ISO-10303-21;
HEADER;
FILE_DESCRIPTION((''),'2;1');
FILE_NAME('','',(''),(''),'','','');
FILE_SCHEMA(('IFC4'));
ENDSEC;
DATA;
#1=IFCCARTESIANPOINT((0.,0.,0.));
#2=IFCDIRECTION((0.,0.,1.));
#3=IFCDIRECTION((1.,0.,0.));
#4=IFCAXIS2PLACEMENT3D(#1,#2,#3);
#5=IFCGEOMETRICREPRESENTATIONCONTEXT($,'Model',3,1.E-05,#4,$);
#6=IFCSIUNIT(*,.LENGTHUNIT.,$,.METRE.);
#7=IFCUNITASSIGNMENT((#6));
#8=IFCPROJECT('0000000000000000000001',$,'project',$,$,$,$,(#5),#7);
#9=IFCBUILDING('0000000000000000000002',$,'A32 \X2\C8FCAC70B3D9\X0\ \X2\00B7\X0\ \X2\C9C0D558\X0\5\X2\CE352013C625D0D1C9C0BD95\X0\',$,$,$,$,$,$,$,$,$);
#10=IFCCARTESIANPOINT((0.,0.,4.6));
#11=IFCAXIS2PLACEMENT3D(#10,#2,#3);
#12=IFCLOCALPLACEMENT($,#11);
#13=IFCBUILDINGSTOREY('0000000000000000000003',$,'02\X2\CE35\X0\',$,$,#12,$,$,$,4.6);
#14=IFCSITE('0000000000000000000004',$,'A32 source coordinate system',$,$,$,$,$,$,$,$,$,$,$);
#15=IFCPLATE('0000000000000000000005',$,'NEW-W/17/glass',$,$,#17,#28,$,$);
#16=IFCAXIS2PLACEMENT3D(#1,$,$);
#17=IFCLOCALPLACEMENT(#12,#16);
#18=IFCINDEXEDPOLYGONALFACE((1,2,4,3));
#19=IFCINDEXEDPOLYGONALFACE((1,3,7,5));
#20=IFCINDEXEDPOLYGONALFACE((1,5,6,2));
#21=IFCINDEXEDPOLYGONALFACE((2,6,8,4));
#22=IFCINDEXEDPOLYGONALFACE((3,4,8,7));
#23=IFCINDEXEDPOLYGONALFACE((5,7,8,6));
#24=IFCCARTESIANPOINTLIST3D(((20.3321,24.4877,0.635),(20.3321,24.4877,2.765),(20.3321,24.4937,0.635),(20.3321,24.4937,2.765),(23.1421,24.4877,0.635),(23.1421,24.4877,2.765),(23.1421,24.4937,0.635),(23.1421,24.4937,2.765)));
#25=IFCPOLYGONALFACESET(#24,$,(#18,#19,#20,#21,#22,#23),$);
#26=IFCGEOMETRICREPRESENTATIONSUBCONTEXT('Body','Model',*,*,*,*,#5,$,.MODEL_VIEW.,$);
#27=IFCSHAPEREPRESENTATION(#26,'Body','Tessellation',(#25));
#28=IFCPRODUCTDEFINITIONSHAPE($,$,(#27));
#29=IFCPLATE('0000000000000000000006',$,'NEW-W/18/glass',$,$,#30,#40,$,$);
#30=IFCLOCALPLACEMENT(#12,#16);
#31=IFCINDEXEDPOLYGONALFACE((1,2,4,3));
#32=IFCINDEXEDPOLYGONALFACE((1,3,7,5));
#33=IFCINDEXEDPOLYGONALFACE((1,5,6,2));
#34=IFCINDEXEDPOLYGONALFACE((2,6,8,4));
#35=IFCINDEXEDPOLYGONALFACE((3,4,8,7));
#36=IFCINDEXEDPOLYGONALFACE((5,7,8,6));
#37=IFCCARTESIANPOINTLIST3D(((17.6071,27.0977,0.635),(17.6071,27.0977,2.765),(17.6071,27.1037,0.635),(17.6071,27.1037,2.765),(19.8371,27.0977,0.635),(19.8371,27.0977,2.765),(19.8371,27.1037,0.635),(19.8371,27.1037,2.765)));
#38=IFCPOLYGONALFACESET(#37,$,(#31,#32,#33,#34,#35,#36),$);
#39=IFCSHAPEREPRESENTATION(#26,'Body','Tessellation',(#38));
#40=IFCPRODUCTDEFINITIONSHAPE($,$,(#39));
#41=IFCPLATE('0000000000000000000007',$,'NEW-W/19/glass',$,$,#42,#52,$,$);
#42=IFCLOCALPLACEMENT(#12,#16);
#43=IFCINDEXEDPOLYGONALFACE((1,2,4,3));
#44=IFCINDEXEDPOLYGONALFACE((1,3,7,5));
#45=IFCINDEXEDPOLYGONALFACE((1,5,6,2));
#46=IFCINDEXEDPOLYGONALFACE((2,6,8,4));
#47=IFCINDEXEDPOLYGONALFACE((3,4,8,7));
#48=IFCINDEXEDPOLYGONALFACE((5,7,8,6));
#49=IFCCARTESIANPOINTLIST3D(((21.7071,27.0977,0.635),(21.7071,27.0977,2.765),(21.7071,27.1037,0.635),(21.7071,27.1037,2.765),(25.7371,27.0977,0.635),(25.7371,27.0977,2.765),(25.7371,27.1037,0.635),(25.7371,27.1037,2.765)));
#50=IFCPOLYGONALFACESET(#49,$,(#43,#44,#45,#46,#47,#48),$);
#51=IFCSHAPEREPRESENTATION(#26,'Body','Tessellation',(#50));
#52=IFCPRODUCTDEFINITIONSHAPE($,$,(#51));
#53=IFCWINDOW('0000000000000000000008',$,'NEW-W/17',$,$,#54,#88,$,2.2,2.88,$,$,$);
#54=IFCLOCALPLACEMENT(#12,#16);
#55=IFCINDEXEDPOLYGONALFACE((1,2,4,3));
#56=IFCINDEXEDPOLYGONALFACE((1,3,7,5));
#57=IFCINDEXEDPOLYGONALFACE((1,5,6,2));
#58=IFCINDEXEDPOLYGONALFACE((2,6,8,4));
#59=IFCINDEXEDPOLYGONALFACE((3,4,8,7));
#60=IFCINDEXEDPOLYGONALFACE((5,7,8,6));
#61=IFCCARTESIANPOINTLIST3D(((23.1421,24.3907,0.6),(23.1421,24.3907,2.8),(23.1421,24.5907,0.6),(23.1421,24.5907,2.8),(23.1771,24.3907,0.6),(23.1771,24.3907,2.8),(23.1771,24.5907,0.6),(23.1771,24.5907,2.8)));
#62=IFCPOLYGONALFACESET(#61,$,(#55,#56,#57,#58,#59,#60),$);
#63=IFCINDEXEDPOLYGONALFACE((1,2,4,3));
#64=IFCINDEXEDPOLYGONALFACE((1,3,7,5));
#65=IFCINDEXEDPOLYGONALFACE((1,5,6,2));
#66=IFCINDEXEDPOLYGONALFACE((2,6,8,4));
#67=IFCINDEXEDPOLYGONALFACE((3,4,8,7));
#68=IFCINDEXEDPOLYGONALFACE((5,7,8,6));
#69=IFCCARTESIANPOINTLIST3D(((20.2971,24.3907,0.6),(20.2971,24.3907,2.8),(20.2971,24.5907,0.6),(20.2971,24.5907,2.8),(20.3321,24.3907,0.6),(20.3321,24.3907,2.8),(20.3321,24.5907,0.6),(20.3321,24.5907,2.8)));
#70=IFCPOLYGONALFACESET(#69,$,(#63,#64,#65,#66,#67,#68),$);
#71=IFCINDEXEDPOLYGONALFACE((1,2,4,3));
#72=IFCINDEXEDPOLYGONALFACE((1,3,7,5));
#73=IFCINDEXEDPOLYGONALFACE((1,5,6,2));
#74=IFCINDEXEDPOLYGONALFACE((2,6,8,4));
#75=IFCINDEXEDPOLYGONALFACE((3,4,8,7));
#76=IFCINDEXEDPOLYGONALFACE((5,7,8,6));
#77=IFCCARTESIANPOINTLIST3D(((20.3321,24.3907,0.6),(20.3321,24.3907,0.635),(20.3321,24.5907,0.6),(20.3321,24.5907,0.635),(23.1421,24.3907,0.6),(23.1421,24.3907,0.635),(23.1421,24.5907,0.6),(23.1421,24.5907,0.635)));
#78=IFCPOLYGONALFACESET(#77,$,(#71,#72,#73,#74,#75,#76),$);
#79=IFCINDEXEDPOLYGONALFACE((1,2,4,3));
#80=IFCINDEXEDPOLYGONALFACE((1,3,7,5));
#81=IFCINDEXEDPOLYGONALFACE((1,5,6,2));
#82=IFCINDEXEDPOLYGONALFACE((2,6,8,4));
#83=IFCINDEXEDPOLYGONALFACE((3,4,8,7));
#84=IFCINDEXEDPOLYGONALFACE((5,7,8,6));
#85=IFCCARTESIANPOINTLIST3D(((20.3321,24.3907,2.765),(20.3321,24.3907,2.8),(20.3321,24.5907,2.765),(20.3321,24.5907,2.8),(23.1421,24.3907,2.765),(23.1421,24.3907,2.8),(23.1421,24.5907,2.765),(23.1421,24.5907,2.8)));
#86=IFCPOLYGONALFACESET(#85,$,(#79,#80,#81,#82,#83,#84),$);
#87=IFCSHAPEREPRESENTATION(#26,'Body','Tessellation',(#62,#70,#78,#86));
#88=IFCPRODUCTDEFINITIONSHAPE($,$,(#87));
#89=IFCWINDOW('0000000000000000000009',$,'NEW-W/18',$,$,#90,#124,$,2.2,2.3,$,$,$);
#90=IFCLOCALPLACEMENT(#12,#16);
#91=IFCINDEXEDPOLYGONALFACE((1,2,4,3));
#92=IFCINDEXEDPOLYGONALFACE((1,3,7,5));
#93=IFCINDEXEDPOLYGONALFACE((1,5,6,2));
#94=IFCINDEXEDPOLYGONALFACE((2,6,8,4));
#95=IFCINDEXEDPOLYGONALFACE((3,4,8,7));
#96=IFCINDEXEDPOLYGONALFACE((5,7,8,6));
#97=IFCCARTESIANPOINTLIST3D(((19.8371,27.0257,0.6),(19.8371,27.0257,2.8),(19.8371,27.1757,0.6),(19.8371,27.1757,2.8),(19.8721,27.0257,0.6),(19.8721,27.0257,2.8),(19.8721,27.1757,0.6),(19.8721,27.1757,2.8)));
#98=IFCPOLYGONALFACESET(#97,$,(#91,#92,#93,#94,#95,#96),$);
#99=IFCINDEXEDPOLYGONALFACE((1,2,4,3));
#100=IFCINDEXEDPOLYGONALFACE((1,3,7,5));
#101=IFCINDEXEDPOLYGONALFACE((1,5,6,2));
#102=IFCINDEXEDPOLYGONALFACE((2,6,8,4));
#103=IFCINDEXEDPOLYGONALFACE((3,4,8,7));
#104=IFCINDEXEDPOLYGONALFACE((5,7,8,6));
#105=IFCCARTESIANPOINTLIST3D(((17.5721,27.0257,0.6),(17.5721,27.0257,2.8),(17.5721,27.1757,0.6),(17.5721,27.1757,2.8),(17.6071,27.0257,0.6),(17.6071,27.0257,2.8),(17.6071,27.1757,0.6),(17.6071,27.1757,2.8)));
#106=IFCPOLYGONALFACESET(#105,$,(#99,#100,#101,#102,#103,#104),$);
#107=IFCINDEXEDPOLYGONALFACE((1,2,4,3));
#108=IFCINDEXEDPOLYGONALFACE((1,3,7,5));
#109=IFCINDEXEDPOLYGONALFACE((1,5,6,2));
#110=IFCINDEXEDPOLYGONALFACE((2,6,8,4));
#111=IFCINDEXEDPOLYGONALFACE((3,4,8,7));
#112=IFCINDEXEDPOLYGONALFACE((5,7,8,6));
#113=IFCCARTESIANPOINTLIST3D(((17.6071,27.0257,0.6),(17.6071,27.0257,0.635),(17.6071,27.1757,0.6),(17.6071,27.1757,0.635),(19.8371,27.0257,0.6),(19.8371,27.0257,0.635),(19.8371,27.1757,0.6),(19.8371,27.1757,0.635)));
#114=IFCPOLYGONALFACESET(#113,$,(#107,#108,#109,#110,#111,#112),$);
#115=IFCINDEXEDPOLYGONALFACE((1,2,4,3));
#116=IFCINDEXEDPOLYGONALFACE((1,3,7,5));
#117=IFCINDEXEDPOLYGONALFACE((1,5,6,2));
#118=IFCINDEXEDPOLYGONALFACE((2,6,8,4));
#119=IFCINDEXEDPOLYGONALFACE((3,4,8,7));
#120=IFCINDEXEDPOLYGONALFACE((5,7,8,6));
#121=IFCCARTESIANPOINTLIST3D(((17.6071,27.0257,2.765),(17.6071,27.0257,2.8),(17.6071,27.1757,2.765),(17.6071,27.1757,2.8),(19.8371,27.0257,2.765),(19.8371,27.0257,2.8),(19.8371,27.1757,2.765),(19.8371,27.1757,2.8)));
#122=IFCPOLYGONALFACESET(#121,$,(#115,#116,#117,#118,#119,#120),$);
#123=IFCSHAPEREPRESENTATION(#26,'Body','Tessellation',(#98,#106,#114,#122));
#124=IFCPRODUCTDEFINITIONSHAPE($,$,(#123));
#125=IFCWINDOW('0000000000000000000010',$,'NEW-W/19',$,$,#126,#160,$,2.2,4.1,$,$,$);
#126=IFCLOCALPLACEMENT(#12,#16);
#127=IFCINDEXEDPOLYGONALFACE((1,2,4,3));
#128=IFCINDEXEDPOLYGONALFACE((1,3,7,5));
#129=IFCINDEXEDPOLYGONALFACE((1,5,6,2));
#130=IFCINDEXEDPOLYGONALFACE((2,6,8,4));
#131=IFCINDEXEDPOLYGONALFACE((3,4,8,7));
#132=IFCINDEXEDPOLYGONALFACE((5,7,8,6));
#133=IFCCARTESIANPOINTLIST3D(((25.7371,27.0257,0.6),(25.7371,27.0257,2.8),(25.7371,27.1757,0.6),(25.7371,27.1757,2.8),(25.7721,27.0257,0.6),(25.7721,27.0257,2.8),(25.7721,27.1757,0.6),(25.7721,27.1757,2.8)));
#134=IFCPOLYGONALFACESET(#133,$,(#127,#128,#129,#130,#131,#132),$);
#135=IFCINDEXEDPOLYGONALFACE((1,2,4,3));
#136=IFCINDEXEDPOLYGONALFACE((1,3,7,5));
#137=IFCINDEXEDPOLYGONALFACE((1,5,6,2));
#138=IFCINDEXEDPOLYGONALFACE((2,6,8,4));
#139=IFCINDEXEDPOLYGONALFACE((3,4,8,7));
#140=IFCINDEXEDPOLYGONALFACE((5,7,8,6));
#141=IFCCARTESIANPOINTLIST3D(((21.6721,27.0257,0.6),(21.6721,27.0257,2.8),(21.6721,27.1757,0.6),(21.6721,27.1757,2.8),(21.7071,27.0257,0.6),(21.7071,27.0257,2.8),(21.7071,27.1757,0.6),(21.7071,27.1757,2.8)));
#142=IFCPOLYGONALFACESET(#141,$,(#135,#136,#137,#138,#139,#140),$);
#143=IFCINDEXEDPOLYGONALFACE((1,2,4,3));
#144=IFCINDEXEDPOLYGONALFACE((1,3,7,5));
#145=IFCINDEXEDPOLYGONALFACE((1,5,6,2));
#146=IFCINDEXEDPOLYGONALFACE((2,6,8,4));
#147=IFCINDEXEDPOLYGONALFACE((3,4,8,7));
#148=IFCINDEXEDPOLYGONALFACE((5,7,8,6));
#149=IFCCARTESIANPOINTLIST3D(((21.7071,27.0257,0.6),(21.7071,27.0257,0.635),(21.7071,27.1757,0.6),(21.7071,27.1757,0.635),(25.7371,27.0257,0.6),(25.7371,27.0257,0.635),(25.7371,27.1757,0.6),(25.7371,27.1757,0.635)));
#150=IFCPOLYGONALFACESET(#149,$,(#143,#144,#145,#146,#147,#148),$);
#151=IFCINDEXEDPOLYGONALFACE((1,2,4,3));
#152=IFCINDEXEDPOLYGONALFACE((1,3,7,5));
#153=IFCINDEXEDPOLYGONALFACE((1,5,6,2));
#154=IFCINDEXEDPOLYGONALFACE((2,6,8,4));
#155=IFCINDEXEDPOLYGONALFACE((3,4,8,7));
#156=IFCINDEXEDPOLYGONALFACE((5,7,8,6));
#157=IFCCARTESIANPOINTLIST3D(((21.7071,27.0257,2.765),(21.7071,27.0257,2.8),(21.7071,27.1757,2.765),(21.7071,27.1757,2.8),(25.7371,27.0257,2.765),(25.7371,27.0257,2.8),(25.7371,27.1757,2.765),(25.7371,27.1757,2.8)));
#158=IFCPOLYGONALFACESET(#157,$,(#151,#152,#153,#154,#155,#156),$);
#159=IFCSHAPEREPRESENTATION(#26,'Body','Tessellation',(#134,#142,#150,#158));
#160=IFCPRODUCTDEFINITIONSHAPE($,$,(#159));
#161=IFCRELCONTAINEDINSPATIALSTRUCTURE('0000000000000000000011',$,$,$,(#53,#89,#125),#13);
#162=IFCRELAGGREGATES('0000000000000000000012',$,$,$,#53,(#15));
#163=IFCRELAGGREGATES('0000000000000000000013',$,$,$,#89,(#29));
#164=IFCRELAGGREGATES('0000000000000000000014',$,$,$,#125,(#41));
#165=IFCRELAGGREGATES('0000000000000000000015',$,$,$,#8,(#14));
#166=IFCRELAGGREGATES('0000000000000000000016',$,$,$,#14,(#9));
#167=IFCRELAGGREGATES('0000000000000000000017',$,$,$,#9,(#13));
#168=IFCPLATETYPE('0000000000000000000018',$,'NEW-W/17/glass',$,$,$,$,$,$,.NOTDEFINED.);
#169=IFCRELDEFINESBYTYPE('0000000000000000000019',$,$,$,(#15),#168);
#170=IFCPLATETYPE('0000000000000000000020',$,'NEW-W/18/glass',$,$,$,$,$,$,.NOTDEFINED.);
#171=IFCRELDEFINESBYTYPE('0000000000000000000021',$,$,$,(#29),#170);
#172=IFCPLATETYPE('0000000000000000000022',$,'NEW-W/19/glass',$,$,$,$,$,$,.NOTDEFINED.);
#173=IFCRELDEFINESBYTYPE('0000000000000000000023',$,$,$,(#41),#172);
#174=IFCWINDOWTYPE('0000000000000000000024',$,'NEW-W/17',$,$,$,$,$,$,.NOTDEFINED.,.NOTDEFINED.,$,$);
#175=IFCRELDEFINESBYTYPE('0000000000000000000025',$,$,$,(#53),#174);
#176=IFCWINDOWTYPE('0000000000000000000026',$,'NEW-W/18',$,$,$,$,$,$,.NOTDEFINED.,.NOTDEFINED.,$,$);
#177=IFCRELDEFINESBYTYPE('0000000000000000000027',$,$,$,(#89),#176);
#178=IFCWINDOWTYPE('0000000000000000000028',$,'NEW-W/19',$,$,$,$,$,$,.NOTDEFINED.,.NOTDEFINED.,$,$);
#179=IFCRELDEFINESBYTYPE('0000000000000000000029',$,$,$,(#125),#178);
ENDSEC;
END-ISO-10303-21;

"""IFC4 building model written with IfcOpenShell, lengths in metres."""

from ifc_helpers import new_model, si_unit, frame, origin, origin_with_axes, place, context, subcontext, project, spatial, polyline, outline, extrude, source, transform, mapped, type_object, type_shapes, element, aggregate, save


model = new_model("IFC4")

# Units and contexts
model_context = context("Model", 3, precision=1e-05, world=origin_with_axes())
body_context = subcontext(model_context, "Body", "Model", "MODEL_VIEW")
ifc_project = project(units=[si_unit("LENGTHUNIT", "METRE")], contexts=[model_context])

# Plates
storey_placement = place(None, frame((0.0, 0.0, 4.6), z_axis=(0.0, 0.0, 1.0), x_axis=(1.0, 0.0, 0.0)))
plate_type_1 = type_object("IfcPlateType", Name="NEW-W/17/glass", PredefinedType="NOTDEFINED")
shared_shape_1 = source(origin(), body_context, "Body", "SweptSolid", [
    extrude(outline(polyline([(23.1421, 24.4877), (20.3321, 24.4877), (20.3321, 24.4937), (23.1421, 24.4937), (23.1421, 24.4877)])), frame((0.0, 0.0, 0.635)), (0.0, 0.0, 1.0), 2.13),
])
type_shapes(plate_type_1, [shared_shape_1])
window_1_placement = place(storey_placement, origin_with_axes())
plate_1_placement = place(window_1_placement, origin_with_axes())
plate_1 = element("IfcPlate", 1, at=plate_1_placement, type_object=plate_type_1, Name="NEW-W/17/glass", context=body_context, shape_type="MappedRepresentation", body=[
    mapped(shared_shape_1, transform((0.0, 0.0, 0.0), scale=1.0)),
])
plate_type_2 = type_object("IfcPlateType", Name="NEW-W/18/glass", PredefinedType="NOTDEFINED")
shared_shape_2 = source(origin(), body_context, "Body", "SweptSolid", [
    extrude(outline(polyline([(19.8371, 27.0977), (17.6071, 27.0977), (17.6071, 27.1037), (19.8371, 27.1037), (19.8371, 27.0977)])), frame((0.0, 0.0, 0.635)), (0.0, 0.0, 1.0), 2.13),
])
type_shapes(plate_type_2, [shared_shape_2])
window_2_placement = place(storey_placement, origin_with_axes())
plate_2_placement = place(window_2_placement, origin_with_axes())
plate_2 = element("IfcPlate", 2, at=plate_2_placement, type_object=plate_type_2, Name="NEW-W/18/glass", context=body_context, shape_type="MappedRepresentation", body=[
    mapped(shared_shape_2, transform((0.0, 0.0, 0.0), scale=1.0)),
])
plate_type_3 = type_object("IfcPlateType", Name="NEW-W/19/glass", PredefinedType="NOTDEFINED")
shared_shape_3 = source(origin(), body_context, "Body", "SweptSolid", [
    extrude(outline(polyline([(25.7371, 27.0977), (21.7071, 27.0977), (21.7071, 27.1037), (25.7371, 27.1037), (25.7371, 27.0977)])), frame((0.0, 0.0, 0.635)), (0.0, 0.0, 1.0), 2.13),
])
type_shapes(plate_type_3, [shared_shape_3])
window_3_placement = place(storey_placement, origin_with_axes())
plate_3_placement = place(window_3_placement, origin_with_axes())
plate_3 = element("IfcPlate", 3, at=plate_3_placement, type_object=plate_type_3, Name="NEW-W/19/glass", context=body_context, shape_type="MappedRepresentation", body=[
    mapped(shared_shape_3, transform((0.0, 0.0, 0.0), scale=1.0)),
])

# Site, building, storey
site = spatial("IfcSite", under=ifc_project, Name="A32 source coordinate system")
building = spatial("IfcBuilding", under=site, Name="A32 주거동 · 지하5층–옥탑지붕")
storey = spatial("IfcBuildingStorey", under=building, at=storey_placement, Name="02층", Elevation=4.6)

# Windows
window_type_1 = type_object("IfcWindowType", Name="NEW-W/17", PartitioningType="NOTDEFINED", PredefinedType="NOTDEFINED")
shared_shape_4 = source(origin(), body_context, "Body", "SweptSolid", [
    extrude(outline(polyline([(23.1421, 24.3907), (23.1421, 24.5907), (23.1771, 24.5907), (23.1771, 24.3907), (23.1421, 24.3907)])), frame((0.0, 0.0, 0.6)), (0.0, 0.0, 1.0), 2.2),
    extrude(outline(polyline([(20.2971, 24.3907), (20.2971, 24.5907), (20.3321, 24.5907), (20.3321, 24.3907), (20.2971, 24.3907)])), frame((0.0, 0.0, 0.6)), (0.0, 0.0, 1.0), 2.2),
    extrude(outline(polyline([(23.1421, 24.3907), (23.1421, 24.5907), (20.3321, 24.5907), (20.3321, 24.3907), (23.1421, 24.3907)])), frame((0.0, 0.0, 0.6)), (0.0, 0.0, 1.0), 0.035),
    extrude(outline(polyline([(23.1421, 24.3907), (23.1421, 24.5907), (20.3321, 24.5907), (20.3321, 24.3907), (23.1421, 24.3907)])), frame((0.0, 0.0, 2.765)), (0.0, 0.0, 1.0), 0.035),
])
type_shapes(window_type_1, [shared_shape_4])
window_1 = element("IfcWindow", 4, at=window_1_placement, inside=storey, type_object=window_type_1, Name="NEW-W/17", OverallHeight=2.2, OverallWidth=2.88, context=body_context, shape_type="MappedRepresentation", body=[
    mapped(shared_shape_4, transform((0.0, 0.0, 0.0), scale=1.0)),
])
aggregate(window_1, [plate_1])
window_type_2 = type_object("IfcWindowType", Name="NEW-W/18", PartitioningType="NOTDEFINED", PredefinedType="NOTDEFINED")
shared_shape_5 = source(origin(), body_context, "Body", "SweptSolid", [
    extrude(outline(polyline([(19.8371, 27.0257), (19.8371, 27.1757), (19.8721, 27.1757), (19.8721, 27.0257), (19.8371, 27.0257)])), frame((0.0, 0.0, 0.6)), (0.0, 0.0, 1.0), 2.2),
    extrude(outline(polyline([(17.5721, 27.0257), (17.5721, 27.1757), (17.6071, 27.1757), (17.6071, 27.0257), (17.5721, 27.0257)])), frame((0.0, 0.0, 0.6)), (0.0, 0.0, 1.0), 2.2),
    extrude(outline(polyline([(19.8371, 27.0257), (19.8371, 27.1757), (17.6071, 27.1757), (17.6071, 27.0257), (19.8371, 27.0257)])), frame((0.0, 0.0, 0.6)), (0.0, 0.0, 1.0), 0.035),
    extrude(outline(polyline([(19.8371, 27.0257), (19.8371, 27.1757), (17.6071, 27.1757), (17.6071, 27.0257), (19.8371, 27.0257)])), frame((0.0, 0.0, 2.765)), (0.0, 0.0, 1.0), 0.035),
])
type_shapes(window_type_2, [shared_shape_5])
window_2 = element("IfcWindow", 5, at=window_2_placement, inside=storey, type_object=window_type_2, Name="NEW-W/18", OverallHeight=2.2, OverallWidth=2.3, context=body_context, shape_type="MappedRepresentation", body=[
    mapped(shared_shape_5, transform((0.0, 0.0, 0.0), scale=1.0)),
])
aggregate(window_2, [plate_2])
window_type_3 = type_object("IfcWindowType", Name="NEW-W/19", PartitioningType="NOTDEFINED", PredefinedType="NOTDEFINED")
shared_shape_6 = source(origin(), body_context, "Body", "SweptSolid", [
    extrude(outline(polyline([(25.7371, 27.0257), (25.7371, 27.1757), (25.7721, 27.1757), (25.7721, 27.0257), (25.7371, 27.0257)])), frame((0.0, 0.0, 0.6)), (0.0, 0.0, 1.0), 2.2),
    extrude(outline(polyline([(21.6721, 27.0257), (21.6721, 27.1757), (21.7071, 27.1757), (21.7071, 27.0257), (21.6721, 27.0257)])), frame((0.0, 0.0, 0.6)), (0.0, 0.0, 1.0), 2.2),
    extrude(outline(polyline([(25.7371, 27.0257), (25.7371, 27.1757), (21.7071, 27.1757), (21.7071, 27.0257), (25.7371, 27.0257)])), frame((0.0, 0.0, 0.6)), (0.0, 0.0, 1.0), 0.035),
    extrude(outline(polyline([(25.7371, 27.0257), (25.7371, 27.1757), (21.7071, 27.1757), (21.7071, 27.0257), (25.7371, 27.0257)])), frame((0.0, 0.0, 2.765)), (0.0, 0.0, 1.0), 0.035),
])
type_shapes(window_type_3, [shared_shape_6])
window_3 = element("IfcWindow", 6, at=window_3_placement, inside=storey, type_object=window_type_3, Name="NEW-W/19", OverallHeight=2.2, OverallWidth=4.1, context=body_context, shape_type="MappedRepresentation", body=[
    mapped(shared_shape_6, transform((0.0, 0.0, 0.0), scale=1.0)),
])
aggregate(window_3, [plate_3])

save(model, "model.ifc")
